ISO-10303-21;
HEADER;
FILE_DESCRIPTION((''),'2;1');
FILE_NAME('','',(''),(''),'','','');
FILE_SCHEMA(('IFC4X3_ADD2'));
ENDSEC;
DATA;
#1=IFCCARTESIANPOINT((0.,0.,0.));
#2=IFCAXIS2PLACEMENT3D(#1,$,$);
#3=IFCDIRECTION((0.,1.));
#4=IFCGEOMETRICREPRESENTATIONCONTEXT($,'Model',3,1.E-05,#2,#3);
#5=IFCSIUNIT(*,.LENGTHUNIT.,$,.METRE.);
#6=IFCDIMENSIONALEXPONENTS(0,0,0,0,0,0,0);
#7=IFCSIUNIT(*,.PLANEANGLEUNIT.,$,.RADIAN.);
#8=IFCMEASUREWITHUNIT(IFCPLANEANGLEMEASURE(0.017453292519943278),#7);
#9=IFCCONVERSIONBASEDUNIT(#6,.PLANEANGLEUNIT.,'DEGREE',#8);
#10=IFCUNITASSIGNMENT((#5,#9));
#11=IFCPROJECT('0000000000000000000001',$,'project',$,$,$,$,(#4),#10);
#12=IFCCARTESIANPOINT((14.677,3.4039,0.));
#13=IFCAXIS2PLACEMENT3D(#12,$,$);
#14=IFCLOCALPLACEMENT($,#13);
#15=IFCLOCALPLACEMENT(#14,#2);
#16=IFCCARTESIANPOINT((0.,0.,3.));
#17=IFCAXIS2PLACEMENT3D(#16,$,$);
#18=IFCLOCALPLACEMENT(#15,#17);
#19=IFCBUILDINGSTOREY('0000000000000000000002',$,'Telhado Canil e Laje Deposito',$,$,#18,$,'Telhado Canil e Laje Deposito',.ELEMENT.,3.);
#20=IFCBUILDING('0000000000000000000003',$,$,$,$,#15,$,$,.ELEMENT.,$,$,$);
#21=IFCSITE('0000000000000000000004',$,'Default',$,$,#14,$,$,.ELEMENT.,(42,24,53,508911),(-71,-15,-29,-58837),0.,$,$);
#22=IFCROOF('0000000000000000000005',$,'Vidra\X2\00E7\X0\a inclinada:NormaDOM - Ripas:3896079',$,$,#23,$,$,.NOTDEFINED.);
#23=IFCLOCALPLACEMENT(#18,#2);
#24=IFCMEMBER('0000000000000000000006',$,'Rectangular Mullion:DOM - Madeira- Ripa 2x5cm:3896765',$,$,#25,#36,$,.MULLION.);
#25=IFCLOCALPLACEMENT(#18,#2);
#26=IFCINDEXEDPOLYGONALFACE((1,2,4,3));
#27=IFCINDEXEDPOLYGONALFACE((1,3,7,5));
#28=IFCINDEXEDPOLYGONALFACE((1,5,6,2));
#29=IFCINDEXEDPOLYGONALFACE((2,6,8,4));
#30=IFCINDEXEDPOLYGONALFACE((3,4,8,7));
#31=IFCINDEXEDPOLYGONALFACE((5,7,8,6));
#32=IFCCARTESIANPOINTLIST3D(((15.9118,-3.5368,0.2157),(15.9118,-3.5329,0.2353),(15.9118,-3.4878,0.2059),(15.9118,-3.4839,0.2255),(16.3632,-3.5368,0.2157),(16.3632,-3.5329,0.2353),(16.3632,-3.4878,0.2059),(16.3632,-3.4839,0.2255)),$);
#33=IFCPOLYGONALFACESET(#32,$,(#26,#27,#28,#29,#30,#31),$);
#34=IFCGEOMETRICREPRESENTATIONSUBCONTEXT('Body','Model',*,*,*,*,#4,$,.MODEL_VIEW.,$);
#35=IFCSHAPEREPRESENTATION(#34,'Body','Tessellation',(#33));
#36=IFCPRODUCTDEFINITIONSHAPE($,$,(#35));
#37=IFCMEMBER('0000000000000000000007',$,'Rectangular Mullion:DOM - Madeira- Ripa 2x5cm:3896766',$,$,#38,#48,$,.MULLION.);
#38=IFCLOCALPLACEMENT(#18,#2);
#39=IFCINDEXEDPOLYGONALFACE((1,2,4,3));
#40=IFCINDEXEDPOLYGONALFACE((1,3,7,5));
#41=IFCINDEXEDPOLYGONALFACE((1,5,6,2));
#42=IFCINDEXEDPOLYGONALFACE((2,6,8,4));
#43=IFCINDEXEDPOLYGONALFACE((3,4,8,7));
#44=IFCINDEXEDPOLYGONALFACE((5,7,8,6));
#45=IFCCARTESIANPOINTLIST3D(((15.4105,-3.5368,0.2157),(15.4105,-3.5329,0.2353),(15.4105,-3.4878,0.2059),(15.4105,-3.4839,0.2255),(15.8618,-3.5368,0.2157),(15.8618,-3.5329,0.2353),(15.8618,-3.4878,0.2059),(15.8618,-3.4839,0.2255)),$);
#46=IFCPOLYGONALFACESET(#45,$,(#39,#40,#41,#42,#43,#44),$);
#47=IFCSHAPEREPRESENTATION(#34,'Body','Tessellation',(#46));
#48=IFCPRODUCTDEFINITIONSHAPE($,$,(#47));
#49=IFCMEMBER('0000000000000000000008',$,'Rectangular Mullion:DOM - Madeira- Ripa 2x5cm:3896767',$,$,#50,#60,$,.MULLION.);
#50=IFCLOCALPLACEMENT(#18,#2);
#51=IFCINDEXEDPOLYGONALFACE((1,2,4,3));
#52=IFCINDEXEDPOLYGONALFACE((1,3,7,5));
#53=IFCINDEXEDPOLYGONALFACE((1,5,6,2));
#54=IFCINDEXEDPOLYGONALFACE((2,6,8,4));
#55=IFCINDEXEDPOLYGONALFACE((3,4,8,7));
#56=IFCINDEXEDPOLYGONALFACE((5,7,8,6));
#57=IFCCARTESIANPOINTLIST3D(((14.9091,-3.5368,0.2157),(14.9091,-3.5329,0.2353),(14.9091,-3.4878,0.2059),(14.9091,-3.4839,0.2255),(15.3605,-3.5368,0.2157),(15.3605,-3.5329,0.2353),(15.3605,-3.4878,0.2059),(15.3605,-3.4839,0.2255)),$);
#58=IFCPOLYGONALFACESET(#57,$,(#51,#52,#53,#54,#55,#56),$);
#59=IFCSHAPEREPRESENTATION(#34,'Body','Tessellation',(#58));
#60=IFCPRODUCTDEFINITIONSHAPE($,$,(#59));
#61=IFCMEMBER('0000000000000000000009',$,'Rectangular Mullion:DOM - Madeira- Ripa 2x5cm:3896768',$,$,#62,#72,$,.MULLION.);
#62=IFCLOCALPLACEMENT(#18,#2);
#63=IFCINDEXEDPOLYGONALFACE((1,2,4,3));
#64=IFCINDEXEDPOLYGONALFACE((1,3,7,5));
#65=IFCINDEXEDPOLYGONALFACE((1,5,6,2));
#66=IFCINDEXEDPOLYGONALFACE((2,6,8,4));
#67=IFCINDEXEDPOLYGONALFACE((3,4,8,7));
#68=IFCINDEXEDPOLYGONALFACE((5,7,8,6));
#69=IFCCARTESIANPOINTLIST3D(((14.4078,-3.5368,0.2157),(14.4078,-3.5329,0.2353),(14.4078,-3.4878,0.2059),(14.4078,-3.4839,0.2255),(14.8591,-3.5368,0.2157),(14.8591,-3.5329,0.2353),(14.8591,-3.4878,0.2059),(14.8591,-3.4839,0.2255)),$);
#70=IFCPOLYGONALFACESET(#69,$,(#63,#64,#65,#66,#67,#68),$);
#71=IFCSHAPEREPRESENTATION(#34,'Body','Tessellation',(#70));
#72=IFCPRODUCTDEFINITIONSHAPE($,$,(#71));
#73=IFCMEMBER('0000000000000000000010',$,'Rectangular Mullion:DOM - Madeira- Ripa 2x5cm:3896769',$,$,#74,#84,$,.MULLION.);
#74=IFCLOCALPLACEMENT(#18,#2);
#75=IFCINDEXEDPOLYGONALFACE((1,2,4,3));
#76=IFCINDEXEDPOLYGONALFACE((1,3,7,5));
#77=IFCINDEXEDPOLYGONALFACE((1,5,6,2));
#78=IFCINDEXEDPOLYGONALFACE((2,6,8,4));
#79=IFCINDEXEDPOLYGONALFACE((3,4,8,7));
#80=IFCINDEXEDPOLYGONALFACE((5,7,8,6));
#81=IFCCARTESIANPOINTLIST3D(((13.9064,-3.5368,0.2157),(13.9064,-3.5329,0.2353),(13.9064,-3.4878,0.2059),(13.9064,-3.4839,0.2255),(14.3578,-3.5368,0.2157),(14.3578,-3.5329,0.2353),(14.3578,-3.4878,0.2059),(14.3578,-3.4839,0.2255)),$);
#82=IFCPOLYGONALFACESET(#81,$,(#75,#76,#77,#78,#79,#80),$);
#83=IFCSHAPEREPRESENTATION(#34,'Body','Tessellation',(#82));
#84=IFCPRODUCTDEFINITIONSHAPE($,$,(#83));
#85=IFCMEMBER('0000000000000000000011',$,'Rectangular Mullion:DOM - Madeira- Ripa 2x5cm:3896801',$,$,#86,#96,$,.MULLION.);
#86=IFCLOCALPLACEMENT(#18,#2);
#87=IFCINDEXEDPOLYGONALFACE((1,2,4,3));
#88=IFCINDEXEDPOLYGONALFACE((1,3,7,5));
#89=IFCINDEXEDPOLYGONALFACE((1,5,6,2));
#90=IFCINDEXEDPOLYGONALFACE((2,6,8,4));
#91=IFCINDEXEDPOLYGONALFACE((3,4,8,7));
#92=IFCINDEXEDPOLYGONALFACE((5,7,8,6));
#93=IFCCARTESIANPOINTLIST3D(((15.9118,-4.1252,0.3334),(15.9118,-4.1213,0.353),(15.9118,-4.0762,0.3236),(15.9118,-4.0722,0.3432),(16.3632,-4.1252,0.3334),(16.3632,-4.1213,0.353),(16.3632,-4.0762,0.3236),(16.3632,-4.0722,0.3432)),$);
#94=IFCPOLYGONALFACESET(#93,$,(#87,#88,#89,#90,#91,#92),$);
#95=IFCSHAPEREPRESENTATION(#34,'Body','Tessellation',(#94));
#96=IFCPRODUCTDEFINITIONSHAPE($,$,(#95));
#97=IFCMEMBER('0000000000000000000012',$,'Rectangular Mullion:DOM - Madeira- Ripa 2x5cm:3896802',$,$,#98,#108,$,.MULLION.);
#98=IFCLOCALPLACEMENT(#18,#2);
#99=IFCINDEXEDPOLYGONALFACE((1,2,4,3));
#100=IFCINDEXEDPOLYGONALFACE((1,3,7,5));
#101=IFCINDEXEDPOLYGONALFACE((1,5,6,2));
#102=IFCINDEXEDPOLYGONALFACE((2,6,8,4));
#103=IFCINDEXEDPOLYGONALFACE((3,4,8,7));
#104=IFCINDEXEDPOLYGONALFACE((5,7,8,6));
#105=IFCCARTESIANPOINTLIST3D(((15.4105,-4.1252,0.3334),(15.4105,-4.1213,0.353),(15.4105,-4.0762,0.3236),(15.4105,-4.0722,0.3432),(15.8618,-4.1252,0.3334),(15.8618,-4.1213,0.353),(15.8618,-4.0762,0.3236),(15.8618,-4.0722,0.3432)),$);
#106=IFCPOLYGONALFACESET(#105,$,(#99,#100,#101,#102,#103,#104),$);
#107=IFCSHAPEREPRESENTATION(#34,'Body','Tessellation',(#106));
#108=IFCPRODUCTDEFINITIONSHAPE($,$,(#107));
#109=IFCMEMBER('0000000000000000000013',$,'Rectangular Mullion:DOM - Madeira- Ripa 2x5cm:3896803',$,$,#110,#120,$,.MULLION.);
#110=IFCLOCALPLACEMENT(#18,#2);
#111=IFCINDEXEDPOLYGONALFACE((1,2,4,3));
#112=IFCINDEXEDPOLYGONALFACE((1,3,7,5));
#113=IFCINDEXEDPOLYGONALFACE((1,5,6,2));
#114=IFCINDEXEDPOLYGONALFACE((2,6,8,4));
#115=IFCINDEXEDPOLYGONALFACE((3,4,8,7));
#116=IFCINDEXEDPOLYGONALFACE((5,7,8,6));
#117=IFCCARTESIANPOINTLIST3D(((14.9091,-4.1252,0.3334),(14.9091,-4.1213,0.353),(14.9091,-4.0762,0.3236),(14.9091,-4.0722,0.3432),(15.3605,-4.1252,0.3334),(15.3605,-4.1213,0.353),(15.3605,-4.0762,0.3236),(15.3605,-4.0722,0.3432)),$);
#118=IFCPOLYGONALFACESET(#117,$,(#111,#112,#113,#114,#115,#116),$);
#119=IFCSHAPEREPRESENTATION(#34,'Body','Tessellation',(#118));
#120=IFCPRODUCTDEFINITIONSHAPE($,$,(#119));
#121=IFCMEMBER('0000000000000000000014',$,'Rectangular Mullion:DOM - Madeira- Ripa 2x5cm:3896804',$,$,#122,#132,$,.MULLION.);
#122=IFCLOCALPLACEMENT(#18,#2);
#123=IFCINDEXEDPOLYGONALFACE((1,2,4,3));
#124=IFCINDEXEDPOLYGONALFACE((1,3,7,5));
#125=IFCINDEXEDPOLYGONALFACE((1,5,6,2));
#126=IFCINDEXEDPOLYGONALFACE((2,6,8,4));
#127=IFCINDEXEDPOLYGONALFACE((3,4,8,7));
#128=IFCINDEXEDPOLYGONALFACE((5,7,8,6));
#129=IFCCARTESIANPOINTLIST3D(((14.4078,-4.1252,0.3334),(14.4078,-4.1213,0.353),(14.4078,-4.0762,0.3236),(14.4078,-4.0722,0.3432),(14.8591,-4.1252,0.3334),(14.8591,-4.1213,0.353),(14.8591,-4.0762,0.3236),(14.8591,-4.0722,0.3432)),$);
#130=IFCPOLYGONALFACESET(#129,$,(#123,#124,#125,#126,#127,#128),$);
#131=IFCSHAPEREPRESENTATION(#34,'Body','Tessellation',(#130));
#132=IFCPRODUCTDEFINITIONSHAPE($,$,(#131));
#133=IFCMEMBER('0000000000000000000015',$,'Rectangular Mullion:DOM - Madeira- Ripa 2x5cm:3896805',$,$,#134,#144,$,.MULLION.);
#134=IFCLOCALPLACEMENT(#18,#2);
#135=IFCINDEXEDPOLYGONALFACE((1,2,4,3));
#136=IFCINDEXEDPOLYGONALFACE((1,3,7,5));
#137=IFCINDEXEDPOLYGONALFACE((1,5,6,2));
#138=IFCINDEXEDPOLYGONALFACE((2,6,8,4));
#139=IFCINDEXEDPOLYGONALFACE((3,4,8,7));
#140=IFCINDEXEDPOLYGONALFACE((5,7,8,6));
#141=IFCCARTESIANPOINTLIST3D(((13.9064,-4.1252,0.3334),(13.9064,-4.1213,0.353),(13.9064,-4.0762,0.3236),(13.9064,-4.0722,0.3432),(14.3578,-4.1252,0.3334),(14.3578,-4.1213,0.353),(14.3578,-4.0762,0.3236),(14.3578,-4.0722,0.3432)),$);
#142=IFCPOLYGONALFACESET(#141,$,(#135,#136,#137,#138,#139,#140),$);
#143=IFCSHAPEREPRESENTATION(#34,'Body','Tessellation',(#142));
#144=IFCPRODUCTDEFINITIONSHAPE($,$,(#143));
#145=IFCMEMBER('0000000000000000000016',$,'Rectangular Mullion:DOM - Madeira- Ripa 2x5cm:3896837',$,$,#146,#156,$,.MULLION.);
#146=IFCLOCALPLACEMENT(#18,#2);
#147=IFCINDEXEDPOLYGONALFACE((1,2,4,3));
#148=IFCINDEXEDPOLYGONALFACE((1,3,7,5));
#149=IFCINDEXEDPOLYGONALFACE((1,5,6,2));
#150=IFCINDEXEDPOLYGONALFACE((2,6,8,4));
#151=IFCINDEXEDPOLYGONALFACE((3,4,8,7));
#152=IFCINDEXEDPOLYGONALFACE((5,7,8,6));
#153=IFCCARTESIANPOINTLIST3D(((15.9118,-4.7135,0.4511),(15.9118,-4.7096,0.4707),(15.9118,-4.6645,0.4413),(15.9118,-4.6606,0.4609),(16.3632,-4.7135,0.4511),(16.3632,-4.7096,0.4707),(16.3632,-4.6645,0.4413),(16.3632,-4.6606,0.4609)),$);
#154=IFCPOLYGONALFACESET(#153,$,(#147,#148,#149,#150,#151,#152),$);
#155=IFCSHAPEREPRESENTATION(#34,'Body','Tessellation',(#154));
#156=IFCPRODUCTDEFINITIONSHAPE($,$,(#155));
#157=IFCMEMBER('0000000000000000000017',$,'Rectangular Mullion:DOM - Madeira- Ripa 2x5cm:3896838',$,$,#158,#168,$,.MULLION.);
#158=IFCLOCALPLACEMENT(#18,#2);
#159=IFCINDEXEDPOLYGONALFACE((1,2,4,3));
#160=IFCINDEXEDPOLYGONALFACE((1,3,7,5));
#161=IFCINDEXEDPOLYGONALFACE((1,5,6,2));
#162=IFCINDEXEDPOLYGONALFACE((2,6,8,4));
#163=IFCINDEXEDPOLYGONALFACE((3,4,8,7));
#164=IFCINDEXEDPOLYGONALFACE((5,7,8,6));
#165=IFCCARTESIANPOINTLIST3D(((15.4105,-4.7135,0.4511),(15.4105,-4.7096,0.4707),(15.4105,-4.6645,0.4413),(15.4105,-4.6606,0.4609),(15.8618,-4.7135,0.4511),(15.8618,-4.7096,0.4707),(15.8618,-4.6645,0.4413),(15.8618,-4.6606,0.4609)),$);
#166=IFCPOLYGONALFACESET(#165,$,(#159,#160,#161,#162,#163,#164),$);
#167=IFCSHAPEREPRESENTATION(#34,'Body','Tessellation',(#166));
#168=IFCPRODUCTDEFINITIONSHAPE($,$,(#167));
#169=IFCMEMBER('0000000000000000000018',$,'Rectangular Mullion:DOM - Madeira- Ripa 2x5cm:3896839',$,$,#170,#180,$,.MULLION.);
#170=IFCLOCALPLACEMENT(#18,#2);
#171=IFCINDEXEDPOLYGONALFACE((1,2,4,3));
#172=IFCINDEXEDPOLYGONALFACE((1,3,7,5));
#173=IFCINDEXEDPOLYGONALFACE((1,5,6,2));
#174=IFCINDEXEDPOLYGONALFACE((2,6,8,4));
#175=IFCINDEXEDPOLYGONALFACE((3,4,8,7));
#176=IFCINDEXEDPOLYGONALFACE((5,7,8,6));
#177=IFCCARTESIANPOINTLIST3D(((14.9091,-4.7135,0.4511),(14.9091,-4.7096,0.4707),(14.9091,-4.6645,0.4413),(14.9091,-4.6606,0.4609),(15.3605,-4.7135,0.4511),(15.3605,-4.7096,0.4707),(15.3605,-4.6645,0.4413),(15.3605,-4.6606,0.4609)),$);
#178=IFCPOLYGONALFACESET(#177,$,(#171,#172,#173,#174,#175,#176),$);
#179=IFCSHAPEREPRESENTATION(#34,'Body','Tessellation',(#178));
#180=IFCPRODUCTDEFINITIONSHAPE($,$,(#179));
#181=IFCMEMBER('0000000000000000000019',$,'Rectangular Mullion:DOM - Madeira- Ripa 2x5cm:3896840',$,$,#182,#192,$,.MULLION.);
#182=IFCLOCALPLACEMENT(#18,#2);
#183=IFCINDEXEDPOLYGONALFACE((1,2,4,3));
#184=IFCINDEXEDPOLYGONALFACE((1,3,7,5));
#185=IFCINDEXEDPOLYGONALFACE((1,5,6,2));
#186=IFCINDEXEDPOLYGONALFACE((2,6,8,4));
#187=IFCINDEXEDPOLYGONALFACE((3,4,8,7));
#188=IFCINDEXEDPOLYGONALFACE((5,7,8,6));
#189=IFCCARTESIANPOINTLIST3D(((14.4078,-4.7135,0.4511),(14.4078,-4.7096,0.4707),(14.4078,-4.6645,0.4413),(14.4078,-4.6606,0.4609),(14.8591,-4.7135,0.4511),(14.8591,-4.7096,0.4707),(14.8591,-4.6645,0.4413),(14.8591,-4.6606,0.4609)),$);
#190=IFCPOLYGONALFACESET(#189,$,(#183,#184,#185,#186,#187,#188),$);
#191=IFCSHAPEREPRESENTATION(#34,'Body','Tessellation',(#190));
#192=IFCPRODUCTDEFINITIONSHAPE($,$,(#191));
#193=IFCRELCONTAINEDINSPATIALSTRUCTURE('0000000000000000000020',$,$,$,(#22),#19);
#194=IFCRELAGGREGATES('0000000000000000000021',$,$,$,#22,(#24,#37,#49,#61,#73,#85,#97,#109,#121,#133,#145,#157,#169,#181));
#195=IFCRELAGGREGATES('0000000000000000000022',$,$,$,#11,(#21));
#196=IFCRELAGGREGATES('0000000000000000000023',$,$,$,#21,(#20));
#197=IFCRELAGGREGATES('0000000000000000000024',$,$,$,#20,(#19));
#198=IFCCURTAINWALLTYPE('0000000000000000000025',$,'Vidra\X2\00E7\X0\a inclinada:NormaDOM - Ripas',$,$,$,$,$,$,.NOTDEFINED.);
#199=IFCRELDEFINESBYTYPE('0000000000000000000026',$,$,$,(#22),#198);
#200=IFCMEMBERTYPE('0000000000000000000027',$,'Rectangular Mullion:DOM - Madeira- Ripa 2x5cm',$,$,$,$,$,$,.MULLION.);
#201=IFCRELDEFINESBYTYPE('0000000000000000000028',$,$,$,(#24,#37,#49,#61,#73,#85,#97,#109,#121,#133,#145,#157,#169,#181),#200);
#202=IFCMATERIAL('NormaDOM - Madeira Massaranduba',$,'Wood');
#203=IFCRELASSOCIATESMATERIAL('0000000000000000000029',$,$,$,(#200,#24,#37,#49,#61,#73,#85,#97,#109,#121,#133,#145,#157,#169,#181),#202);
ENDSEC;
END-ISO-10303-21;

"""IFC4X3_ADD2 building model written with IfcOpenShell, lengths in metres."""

from ifc_helpers import new_model, entity, si_unit, converted_unit, direction, frame, origin, origin_2d_with_axis, place, context, subcontext, project, spatial, rectangle, extrude, source, transform, mapped, material, material_profile, profile_set, profile_usage, type_object, type_shapes, element, aggregate, save


model = new_model("IFC4X3_ADD2")

# Units and contexts
model_context = context("Model", 3, precision=1e-05, world=origin(), true_north=direction((0.0, 1.0)))
body_context = subcontext(model_context, "Body", "Model", "MODEL_VIEW")
ifc_project = project(units=[si_unit("LENGTHUNIT", "METRE"), converted_unit("PLANEANGLEUNIT", "DEGREE", entity("IfcPlaneAngleMeasure", 0.017453292519943278), si_unit("PLANEANGLEUNIT", "RADIAN"), dimensions=[0, 0, 0, 0, 0, 0, 0])], contexts=[model_context])

# Site, building, storey
site_placement = place(None, frame((14.677, 3.4039, 0.0)))
site = spatial("IfcSite", under=ifc_project, at=site_placement, Name="Default", CompositionType="ELEMENT", RefLatitude=(42, 24, 53, 508911), RefLongitude=(-71, -15, -29, -58837), RefElevation=0.0)
building_placement = place(site_placement, origin())
building = spatial("IfcBuilding", under=site, at=building_placement, CompositionType="ELEMENT")
storey_placement = place(building_placement, frame((0.0, 0.0, 3.0)))
storey = spatial("IfcBuildingStorey", under=building, at=storey_placement, Name="Telhado Canil e Laje Deposito", LongName="Telhado Canil e Laje Deposito", CompositionType="ELEMENT", Elevation=3.0)

# Roof
curtain_wall_type_1 = type_object("IfcCurtainWallType", Name="Vidraça inclinada:NormaDOM - Ripas", PredefinedType="NOTDEFINED")
roof_1_placement = place(storey_placement, frame((0.0, 0.0, -3.0)))
roof_1 = element("IfcRoof", 1, at=roof_1_placement, inside=storey, type_object=curtain_wall_type_1, Name="Vidraça inclinada:NormaDOM - Ripas:3896079", PredefinedType="NOTDEFINED")
ifc_material = material(Name="NormaDOM - Madeira Massaranduba", Category="Wood")

# Members
ifc_material_profile_1 = material_profile(ifc_material, rectangle(XDim=0.05, YDim=0.02, at=origin_2d_with_axis()), Name="DOM - Madeira- Ripa 2x5cm")
ifc_profile_set_1 = profile_set([ifc_material_profile_1], Name="DOM - Madeira- Ripa 2x5cm")
ifc_profile_usage_1 = profile_usage(ifc_profile_set_1)
member_type_1 = type_object("IfcMemberType", Name="Rectangular Mullion:DOM - Madeira- Ripa 2x5cm", PredefinedType="MULLION", material=ifc_profile_set_1)
shared_shape_1 = source(origin(), body_context, "Body", "SweptSolid", [
    extrude(rectangle(XDim=0.05, YDim=0.02, at=origin_2d_with_axis()), frame((0.025, 0.01, -0.4514), z_axis=(0.0, 0.0, 1.0), x_axis=(-1.0, 0.0, 0.0)), (0.0, 0.0, 1.0), 0.4514),
])
type_shapes(member_type_1, [shared_shape_1])
member_1_placement = place(roof_1_placement, frame((16.3632, -3.4839, 3.2255), z_axis=(1.0, 0.0, 0.0), x_axis=(0.0, -0.980581, 0.196116)))
member_1 = element("IfcMember", 2, at=member_1_placement, type_object=member_type_1, material=ifc_profile_usage_1, Name="Rectangular Mullion:DOM - Madeira- Ripa 2x5cm:3896765", PredefinedType="MULLION", context=body_context, shape_type="MappedRepresentation", body=[
    mapped(shared_shape_1, transform((0.0, 0.0, 0.0), scale=1.0)),
])
member_2_placement = place(roof_1_placement, frame((15.8618, -3.4839, 3.2255), z_axis=(1.0, 0.0, 0.0), x_axis=(0.0, -0.980581, 0.196116)))
member_2 = element("IfcMember", 3, at=member_2_placement, type_object=member_type_1, material=ifc_profile_usage_1, Name="Rectangular Mullion:DOM - Madeira- Ripa 2x5cm:3896766", PredefinedType="MULLION", context=body_context, shape_type="MappedRepresentation", body=[
    mapped(shared_shape_1, transform((0.0, 0.0, 0.0), scale=1.0)),
])
member_3_placement = place(roof_1_placement, frame((15.3605, -3.4839, 3.2255), z_axis=(1.0, 0.0, 0.0), x_axis=(0.0, -0.980581, 0.196116)))
member_3 = element("IfcMember", 4, at=member_3_placement, type_object=member_type_1, material=ifc_profile_usage_1, Name="Rectangular Mullion:DOM - Madeira- Ripa 2x5cm:3896767", PredefinedType="MULLION", context=body_context, shape_type="MappedRepresentation", body=[
    mapped(shared_shape_1, transform((0.0, 0.0, 0.0), scale=1.0)),
])
member_4_placement = place(roof_1_placement, frame((14.8591, -3.4839, 3.2255), z_axis=(1.0, 0.0, 0.0), x_axis=(0.0, -0.980581, 0.196116)))
member_4 = element("IfcMember", 5, at=member_4_placement, type_object=member_type_1, material=ifc_profile_usage_1, Name="Rectangular Mullion:DOM - Madeira- Ripa 2x5cm:3896768", PredefinedType="MULLION", context=body_context, shape_type="MappedRepresentation", body=[
    mapped(shared_shape_1, transform((0.0, 0.0, 0.0), scale=1.0)),
])
member_5_placement = place(roof_1_placement, frame((14.3578, -3.4839, 3.2255), z_axis=(1.0, 0.0, 0.0), x_axis=(0.0, -0.980581, 0.196116)))
member_5 = element("IfcMember", 6, at=member_5_placement, type_object=member_type_1, material=ifc_profile_usage_1, Name="Rectangular Mullion:DOM - Madeira- Ripa 2x5cm:3896769", PredefinedType="MULLION", context=body_context, shape_type="MappedRepresentation", body=[
    mapped(shared_shape_1, transform((0.0, 0.0, 0.0), scale=1.0)),
])
member_6_placement = place(roof_1_placement, frame((16.3632, -4.0722, 3.3432), z_axis=(1.0, 0.0, 0.0), x_axis=(0.0, -0.980581, 0.196116)))
member_6 = element("IfcMember", 7, at=member_6_placement, type_object=member_type_1, material=ifc_profile_usage_1, Name="Rectangular Mullion:DOM - Madeira- Ripa 2x5cm:3896801", PredefinedType="MULLION", context=body_context, shape_type="MappedRepresentation", body=[
    mapped(shared_shape_1, transform((0.0, 0.0, 0.0), scale=1.0)),
])
member_7_placement = place(roof_1_placement, frame((15.8618, -4.0722, 3.3432), z_axis=(1.0, 0.0, 0.0), x_axis=(0.0, -0.980581, 0.196116)))
member_7 = element("IfcMember", 8, at=member_7_placement, type_object=member_type_1, material=ifc_profile_usage_1, Name="Rectangular Mullion:DOM - Madeira- Ripa 2x5cm:3896802", PredefinedType="MULLION", context=body_context, shape_type="MappedRepresentation", body=[
    mapped(shared_shape_1, transform((0.0, 0.0, 0.0), scale=1.0)),
])
member_8_placement = place(roof_1_placement, frame((15.3605, -4.0722, 3.3432), z_axis=(1.0, 0.0, 0.0), x_axis=(0.0, -0.980581, 0.196116)))
member_8 = element("IfcMember", 9, at=member_8_placement, type_object=member_type_1, material=ifc_profile_usage_1, Name="Rectangular Mullion:DOM - Madeira- Ripa 2x5cm:3896803", PredefinedType="MULLION", context=body_context, shape_type="MappedRepresentation", body=[
    mapped(shared_shape_1, transform((0.0, 0.0, 0.0), scale=1.0)),
])
member_9_placement = place(roof_1_placement, frame((14.8591, -4.0722, 3.3432), z_axis=(1.0, 0.0, 0.0), x_axis=(0.0, -0.980581, 0.196116)))
member_9 = element("IfcMember", 10, at=member_9_placement, type_object=member_type_1, material=ifc_profile_usage_1, Name="Rectangular Mullion:DOM - Madeira- Ripa 2x5cm:3896804", PredefinedType="MULLION", context=body_context, shape_type="MappedRepresentation", body=[
    mapped(shared_shape_1, transform((0.0, 0.0, 0.0), scale=1.0)),
])
member_10_placement = place(roof_1_placement, frame((14.3578, -4.0722, 3.3432), z_axis=(1.0, 0.0, 0.0), x_axis=(0.0, -0.980581, 0.196116)))
member_10 = element("IfcMember", 11, at=member_10_placement, type_object=member_type_1, material=ifc_profile_usage_1, Name="Rectangular Mullion:DOM - Madeira- Ripa 2x5cm:3896805", PredefinedType="MULLION", context=body_context, shape_type="MappedRepresentation", body=[
    mapped(shared_shape_1, transform((0.0, 0.0, 0.0), scale=1.0)),
])
member_11_placement = place(roof_1_placement, frame((16.3632, -4.6606, 3.4609), z_axis=(1.0, 0.0, 0.0), x_axis=(0.0, -0.980581, 0.196116)))
member_11 = element("IfcMember", 12, at=member_11_placement, type_object=member_type_1, material=ifc_profile_usage_1, Name="Rectangular Mullion:DOM - Madeira- Ripa 2x5cm:3896837", PredefinedType="MULLION", context=body_context, shape_type="MappedRepresentation", body=[
    mapped(shared_shape_1, transform((0.0, 0.0, 0.0), scale=1.0)),
])
member_12_placement = place(roof_1_placement, frame((15.8618, -4.6606, 3.4609), z_axis=(1.0, 0.0, 0.0), x_axis=(0.0, -0.980581, 0.196116)))
member_12 = element("IfcMember", 13, at=member_12_placement, type_object=member_type_1, material=ifc_profile_usage_1, Name="Rectangular Mullion:DOM - Madeira- Ripa 2x5cm:3896838", PredefinedType="MULLION", context=body_context, shape_type="MappedRepresentation", body=[
    mapped(shared_shape_1, transform((0.0, 0.0, 0.0), scale=1.0)),
])
member_13_placement = place(roof_1_placement, frame((15.3605, -4.6606, 3.4609), z_axis=(1.0, 0.0, 0.0), x_axis=(0.0, -0.980581, 0.196116)))
member_13 = element("IfcMember", 14, at=member_13_placement, type_object=member_type_1, material=ifc_profile_usage_1, Name="Rectangular Mullion:DOM - Madeira- Ripa 2x5cm:3896839", PredefinedType="MULLION", context=body_context, shape_type="MappedRepresentation", body=[
    mapped(shared_shape_1, transform((0.0, 0.0, 0.0), scale=1.0)),
])
member_14_placement = place(roof_1_placement, frame((14.8591, -4.6606, 3.4609), z_axis=(1.0, 0.0, 0.0), x_axis=(0.0, -0.980581, 0.196116)))
member_14 = element("IfcMember", 15, at=member_14_placement, type_object=member_type_1, material=ifc_profile_usage_1, Name="Rectangular Mullion:DOM - Madeira- Ripa 2x5cm:3896840", PredefinedType="MULLION", context=body_context, shape_type="MappedRepresentation", body=[
    mapped(shared_shape_1, transform((0.0, 0.0, 0.0), scale=1.0)),
])
aggregate(roof_1, [member_1, member_2, member_3, member_4, member_5, member_6, member_7, member_8, member_9, member_10, member_11, member_12, member_13, member_14])

save(model, "model.ifc")
